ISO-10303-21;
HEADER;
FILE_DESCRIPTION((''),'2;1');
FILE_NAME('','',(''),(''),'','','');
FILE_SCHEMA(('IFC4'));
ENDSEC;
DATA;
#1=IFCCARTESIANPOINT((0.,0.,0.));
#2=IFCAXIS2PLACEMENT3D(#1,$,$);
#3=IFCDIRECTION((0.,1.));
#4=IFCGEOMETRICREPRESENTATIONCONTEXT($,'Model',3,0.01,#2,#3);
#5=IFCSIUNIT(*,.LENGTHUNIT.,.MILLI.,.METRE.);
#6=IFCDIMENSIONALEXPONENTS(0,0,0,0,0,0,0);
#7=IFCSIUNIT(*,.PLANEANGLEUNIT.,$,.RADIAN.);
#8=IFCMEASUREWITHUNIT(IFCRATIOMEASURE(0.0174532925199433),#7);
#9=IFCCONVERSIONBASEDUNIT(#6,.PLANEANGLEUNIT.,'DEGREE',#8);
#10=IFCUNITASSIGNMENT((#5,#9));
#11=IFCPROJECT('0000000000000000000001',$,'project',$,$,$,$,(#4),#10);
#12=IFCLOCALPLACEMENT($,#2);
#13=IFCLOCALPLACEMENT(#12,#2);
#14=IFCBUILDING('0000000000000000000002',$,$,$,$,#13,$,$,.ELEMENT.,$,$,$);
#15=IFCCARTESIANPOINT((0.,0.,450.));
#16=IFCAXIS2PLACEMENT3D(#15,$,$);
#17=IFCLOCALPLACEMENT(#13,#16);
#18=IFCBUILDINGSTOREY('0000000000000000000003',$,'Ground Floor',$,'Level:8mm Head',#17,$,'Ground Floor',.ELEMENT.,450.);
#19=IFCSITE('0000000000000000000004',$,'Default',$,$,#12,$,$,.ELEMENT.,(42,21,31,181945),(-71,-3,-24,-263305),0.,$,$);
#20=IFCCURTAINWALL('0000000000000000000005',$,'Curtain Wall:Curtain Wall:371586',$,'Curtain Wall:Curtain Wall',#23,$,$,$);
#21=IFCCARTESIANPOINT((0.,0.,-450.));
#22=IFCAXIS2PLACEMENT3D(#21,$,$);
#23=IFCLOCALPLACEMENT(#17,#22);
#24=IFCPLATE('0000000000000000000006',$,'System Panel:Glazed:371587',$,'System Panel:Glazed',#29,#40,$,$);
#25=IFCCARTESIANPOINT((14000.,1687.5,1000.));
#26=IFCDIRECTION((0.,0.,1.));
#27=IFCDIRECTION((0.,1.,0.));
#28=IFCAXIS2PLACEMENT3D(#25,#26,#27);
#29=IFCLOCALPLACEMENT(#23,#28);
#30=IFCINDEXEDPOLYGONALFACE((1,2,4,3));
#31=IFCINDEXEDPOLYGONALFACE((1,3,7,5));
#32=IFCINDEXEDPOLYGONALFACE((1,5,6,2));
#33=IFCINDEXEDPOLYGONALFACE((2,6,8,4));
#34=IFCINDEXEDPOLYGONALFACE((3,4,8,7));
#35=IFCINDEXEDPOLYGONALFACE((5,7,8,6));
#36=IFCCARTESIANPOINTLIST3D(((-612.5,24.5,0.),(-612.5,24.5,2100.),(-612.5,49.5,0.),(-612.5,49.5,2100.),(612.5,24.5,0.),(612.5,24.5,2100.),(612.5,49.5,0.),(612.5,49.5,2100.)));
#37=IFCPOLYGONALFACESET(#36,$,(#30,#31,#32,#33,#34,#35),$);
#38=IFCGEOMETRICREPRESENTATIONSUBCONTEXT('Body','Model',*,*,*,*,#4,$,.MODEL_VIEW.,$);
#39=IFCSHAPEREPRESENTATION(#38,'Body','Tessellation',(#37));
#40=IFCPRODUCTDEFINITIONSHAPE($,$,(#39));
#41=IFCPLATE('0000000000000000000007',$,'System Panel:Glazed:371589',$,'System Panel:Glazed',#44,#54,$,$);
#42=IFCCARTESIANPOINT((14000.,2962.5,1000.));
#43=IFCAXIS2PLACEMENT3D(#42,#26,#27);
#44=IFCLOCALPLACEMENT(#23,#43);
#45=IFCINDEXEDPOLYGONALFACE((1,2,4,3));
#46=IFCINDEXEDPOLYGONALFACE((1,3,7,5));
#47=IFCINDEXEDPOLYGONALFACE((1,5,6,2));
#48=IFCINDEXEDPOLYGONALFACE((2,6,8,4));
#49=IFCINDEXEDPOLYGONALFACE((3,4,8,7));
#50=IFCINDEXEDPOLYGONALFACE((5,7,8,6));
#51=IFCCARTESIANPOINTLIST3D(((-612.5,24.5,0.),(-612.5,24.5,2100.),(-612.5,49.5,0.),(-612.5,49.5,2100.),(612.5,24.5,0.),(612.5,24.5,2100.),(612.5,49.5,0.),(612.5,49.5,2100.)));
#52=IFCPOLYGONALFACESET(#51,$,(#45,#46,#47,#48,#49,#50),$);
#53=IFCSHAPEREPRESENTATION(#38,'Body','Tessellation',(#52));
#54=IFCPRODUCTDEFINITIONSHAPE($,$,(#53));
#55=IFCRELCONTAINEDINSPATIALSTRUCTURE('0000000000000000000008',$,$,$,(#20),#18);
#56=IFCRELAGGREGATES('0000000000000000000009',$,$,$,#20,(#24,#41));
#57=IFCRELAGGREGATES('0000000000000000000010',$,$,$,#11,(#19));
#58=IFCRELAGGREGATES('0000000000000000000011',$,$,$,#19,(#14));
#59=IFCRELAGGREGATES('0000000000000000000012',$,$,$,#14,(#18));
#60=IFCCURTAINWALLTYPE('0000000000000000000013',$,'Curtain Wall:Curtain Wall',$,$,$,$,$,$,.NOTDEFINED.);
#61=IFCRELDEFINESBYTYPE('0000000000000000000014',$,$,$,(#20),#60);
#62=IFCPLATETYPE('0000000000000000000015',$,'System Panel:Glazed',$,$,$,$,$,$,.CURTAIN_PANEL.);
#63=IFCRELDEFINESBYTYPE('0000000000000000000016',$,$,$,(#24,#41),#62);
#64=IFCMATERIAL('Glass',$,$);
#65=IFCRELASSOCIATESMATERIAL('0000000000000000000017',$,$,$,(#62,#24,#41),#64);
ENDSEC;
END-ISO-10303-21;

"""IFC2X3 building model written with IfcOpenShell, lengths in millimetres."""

from ifc_helpers import new_model, entity, si_unit, converted_unit, direction, frame, origin, origin_2d_with_axis, place, context, subcontext, project, spatial, rectangle, extrude, source, transform, mapped, material, type_object, type_shapes, element, aggregate, save


model = new_model("IFC2X3")

# Units and contexts
model_context = context("Model", 3, precision=0.01, world=origin(), true_north=direction((0.0, 1.0)))
body_context = subcontext(model_context, "Body", "Model", "MODEL_VIEW")
ifc_project = project(units=[si_unit("LENGTHUNIT", "METRE", prefix="MILLI"), converted_unit("PLANEANGLEUNIT", "DEGREE", entity("IfcRatioMeasure", 0.0174532925199433), si_unit("PLANEANGLEUNIT", "RADIAN"), dimensions=[0, 0, 0, 0, 0, 0, 0])], contexts=[model_context])

# Site, building, storey
site_placement = place(None, origin())
site = spatial("IfcSite", under=ifc_project, at=site_placement, Name="Default", CompositionType="ELEMENT", RefLatitude=(42, 21, 31, 181945), RefLongitude=(-71, -3, -24, -263305), RefElevation=0.0)
building_placement = place(site_placement, origin())
building = spatial("IfcBuilding", under=site, at=building_placement, CompositionType="ELEMENT")
storey_placement = place(building_placement, frame((0.0, 0.0, 450.0)))
storey = spatial("IfcBuildingStorey", under=building, at=storey_placement, Name="Ground Floor", ObjectType="Level:8mm Head", LongName="Ground Floor", CompositionType="ELEMENT", Elevation=450.0)

# Curtain wall, plates
curtain_wall_type = type_object("IfcCurtainWallType", Name="Curtain Wall:Curtain Wall", PredefinedType="NOTDEFINED")
curtain_wall_placement = place(storey_placement, frame((0.0, 0.0, -450.0)))
curtain_wall = element("IfcCurtainWall", 1, at=curtain_wall_placement, inside=storey, type_object=curtain_wall_type, Name="Curtain Wall:Curtain Wall:371586", ObjectType="Curtain Wall:Curtain Wall")
ifc_material_1 = material(Name="Glass")
plate_type = type_object("IfcPlateType", Name="System Panel:Glazed", PredefinedType="CURTAIN_PANEL", material=ifc_material_1)
shared_shape_1 = source(origin(), body_context, "Body", "SweptSolid", [
    extrude(rectangle(XDim=25.0, YDim=1225.0, at=origin_2d_with_axis()), frame((0.0, 37.0, 0.0), z_axis=(0.0, 0.0, 1.0), x_axis=(0.0, 1.0, 0.0)), (0.0, 0.0, 1.0), 2100.0),
])
type_shapes(plate_type, [shared_shape_1])
plate_1_placement = place(curtain_wall_placement, frame((14000.0, 1687.5, 1000.0), z_axis=(0.0, 0.0, 1.0), x_axis=(0.0, 1.0, 0.0)))
plate_1 = element("IfcPlate", 2, at=plate_1_placement, type_object=plate_type, material=ifc_material_1, Name="System Panel:Glazed:371587", ObjectType="System Panel:Glazed", context=body_context, shape_type="MappedRepresentation", body=[
    mapped(shared_shape_1, transform((0.0, 0.0, 0.0), scale=1.0)),
])
plate_2_placement = place(curtain_wall_placement, frame((14000.0, 2962.5, 1000.0), z_axis=(0.0, 0.0, 1.0), x_axis=(0.0, 1.0, 0.0)))
plate_2 = element("IfcPlate", 3, at=plate_2_placement, type_object=plate_type, material=ifc_material_1, Name="System Panel:Glazed:371589", ObjectType="System Panel:Glazed", context=body_context, shape_type="MappedRepresentation", body=[
    mapped(shared_shape_1, transform((0.0, 0.0, 0.0), scale=1.0)),
])
aggregate(curtain_wall, [plate_1, plate_2])

save(model, "model.ifc")
